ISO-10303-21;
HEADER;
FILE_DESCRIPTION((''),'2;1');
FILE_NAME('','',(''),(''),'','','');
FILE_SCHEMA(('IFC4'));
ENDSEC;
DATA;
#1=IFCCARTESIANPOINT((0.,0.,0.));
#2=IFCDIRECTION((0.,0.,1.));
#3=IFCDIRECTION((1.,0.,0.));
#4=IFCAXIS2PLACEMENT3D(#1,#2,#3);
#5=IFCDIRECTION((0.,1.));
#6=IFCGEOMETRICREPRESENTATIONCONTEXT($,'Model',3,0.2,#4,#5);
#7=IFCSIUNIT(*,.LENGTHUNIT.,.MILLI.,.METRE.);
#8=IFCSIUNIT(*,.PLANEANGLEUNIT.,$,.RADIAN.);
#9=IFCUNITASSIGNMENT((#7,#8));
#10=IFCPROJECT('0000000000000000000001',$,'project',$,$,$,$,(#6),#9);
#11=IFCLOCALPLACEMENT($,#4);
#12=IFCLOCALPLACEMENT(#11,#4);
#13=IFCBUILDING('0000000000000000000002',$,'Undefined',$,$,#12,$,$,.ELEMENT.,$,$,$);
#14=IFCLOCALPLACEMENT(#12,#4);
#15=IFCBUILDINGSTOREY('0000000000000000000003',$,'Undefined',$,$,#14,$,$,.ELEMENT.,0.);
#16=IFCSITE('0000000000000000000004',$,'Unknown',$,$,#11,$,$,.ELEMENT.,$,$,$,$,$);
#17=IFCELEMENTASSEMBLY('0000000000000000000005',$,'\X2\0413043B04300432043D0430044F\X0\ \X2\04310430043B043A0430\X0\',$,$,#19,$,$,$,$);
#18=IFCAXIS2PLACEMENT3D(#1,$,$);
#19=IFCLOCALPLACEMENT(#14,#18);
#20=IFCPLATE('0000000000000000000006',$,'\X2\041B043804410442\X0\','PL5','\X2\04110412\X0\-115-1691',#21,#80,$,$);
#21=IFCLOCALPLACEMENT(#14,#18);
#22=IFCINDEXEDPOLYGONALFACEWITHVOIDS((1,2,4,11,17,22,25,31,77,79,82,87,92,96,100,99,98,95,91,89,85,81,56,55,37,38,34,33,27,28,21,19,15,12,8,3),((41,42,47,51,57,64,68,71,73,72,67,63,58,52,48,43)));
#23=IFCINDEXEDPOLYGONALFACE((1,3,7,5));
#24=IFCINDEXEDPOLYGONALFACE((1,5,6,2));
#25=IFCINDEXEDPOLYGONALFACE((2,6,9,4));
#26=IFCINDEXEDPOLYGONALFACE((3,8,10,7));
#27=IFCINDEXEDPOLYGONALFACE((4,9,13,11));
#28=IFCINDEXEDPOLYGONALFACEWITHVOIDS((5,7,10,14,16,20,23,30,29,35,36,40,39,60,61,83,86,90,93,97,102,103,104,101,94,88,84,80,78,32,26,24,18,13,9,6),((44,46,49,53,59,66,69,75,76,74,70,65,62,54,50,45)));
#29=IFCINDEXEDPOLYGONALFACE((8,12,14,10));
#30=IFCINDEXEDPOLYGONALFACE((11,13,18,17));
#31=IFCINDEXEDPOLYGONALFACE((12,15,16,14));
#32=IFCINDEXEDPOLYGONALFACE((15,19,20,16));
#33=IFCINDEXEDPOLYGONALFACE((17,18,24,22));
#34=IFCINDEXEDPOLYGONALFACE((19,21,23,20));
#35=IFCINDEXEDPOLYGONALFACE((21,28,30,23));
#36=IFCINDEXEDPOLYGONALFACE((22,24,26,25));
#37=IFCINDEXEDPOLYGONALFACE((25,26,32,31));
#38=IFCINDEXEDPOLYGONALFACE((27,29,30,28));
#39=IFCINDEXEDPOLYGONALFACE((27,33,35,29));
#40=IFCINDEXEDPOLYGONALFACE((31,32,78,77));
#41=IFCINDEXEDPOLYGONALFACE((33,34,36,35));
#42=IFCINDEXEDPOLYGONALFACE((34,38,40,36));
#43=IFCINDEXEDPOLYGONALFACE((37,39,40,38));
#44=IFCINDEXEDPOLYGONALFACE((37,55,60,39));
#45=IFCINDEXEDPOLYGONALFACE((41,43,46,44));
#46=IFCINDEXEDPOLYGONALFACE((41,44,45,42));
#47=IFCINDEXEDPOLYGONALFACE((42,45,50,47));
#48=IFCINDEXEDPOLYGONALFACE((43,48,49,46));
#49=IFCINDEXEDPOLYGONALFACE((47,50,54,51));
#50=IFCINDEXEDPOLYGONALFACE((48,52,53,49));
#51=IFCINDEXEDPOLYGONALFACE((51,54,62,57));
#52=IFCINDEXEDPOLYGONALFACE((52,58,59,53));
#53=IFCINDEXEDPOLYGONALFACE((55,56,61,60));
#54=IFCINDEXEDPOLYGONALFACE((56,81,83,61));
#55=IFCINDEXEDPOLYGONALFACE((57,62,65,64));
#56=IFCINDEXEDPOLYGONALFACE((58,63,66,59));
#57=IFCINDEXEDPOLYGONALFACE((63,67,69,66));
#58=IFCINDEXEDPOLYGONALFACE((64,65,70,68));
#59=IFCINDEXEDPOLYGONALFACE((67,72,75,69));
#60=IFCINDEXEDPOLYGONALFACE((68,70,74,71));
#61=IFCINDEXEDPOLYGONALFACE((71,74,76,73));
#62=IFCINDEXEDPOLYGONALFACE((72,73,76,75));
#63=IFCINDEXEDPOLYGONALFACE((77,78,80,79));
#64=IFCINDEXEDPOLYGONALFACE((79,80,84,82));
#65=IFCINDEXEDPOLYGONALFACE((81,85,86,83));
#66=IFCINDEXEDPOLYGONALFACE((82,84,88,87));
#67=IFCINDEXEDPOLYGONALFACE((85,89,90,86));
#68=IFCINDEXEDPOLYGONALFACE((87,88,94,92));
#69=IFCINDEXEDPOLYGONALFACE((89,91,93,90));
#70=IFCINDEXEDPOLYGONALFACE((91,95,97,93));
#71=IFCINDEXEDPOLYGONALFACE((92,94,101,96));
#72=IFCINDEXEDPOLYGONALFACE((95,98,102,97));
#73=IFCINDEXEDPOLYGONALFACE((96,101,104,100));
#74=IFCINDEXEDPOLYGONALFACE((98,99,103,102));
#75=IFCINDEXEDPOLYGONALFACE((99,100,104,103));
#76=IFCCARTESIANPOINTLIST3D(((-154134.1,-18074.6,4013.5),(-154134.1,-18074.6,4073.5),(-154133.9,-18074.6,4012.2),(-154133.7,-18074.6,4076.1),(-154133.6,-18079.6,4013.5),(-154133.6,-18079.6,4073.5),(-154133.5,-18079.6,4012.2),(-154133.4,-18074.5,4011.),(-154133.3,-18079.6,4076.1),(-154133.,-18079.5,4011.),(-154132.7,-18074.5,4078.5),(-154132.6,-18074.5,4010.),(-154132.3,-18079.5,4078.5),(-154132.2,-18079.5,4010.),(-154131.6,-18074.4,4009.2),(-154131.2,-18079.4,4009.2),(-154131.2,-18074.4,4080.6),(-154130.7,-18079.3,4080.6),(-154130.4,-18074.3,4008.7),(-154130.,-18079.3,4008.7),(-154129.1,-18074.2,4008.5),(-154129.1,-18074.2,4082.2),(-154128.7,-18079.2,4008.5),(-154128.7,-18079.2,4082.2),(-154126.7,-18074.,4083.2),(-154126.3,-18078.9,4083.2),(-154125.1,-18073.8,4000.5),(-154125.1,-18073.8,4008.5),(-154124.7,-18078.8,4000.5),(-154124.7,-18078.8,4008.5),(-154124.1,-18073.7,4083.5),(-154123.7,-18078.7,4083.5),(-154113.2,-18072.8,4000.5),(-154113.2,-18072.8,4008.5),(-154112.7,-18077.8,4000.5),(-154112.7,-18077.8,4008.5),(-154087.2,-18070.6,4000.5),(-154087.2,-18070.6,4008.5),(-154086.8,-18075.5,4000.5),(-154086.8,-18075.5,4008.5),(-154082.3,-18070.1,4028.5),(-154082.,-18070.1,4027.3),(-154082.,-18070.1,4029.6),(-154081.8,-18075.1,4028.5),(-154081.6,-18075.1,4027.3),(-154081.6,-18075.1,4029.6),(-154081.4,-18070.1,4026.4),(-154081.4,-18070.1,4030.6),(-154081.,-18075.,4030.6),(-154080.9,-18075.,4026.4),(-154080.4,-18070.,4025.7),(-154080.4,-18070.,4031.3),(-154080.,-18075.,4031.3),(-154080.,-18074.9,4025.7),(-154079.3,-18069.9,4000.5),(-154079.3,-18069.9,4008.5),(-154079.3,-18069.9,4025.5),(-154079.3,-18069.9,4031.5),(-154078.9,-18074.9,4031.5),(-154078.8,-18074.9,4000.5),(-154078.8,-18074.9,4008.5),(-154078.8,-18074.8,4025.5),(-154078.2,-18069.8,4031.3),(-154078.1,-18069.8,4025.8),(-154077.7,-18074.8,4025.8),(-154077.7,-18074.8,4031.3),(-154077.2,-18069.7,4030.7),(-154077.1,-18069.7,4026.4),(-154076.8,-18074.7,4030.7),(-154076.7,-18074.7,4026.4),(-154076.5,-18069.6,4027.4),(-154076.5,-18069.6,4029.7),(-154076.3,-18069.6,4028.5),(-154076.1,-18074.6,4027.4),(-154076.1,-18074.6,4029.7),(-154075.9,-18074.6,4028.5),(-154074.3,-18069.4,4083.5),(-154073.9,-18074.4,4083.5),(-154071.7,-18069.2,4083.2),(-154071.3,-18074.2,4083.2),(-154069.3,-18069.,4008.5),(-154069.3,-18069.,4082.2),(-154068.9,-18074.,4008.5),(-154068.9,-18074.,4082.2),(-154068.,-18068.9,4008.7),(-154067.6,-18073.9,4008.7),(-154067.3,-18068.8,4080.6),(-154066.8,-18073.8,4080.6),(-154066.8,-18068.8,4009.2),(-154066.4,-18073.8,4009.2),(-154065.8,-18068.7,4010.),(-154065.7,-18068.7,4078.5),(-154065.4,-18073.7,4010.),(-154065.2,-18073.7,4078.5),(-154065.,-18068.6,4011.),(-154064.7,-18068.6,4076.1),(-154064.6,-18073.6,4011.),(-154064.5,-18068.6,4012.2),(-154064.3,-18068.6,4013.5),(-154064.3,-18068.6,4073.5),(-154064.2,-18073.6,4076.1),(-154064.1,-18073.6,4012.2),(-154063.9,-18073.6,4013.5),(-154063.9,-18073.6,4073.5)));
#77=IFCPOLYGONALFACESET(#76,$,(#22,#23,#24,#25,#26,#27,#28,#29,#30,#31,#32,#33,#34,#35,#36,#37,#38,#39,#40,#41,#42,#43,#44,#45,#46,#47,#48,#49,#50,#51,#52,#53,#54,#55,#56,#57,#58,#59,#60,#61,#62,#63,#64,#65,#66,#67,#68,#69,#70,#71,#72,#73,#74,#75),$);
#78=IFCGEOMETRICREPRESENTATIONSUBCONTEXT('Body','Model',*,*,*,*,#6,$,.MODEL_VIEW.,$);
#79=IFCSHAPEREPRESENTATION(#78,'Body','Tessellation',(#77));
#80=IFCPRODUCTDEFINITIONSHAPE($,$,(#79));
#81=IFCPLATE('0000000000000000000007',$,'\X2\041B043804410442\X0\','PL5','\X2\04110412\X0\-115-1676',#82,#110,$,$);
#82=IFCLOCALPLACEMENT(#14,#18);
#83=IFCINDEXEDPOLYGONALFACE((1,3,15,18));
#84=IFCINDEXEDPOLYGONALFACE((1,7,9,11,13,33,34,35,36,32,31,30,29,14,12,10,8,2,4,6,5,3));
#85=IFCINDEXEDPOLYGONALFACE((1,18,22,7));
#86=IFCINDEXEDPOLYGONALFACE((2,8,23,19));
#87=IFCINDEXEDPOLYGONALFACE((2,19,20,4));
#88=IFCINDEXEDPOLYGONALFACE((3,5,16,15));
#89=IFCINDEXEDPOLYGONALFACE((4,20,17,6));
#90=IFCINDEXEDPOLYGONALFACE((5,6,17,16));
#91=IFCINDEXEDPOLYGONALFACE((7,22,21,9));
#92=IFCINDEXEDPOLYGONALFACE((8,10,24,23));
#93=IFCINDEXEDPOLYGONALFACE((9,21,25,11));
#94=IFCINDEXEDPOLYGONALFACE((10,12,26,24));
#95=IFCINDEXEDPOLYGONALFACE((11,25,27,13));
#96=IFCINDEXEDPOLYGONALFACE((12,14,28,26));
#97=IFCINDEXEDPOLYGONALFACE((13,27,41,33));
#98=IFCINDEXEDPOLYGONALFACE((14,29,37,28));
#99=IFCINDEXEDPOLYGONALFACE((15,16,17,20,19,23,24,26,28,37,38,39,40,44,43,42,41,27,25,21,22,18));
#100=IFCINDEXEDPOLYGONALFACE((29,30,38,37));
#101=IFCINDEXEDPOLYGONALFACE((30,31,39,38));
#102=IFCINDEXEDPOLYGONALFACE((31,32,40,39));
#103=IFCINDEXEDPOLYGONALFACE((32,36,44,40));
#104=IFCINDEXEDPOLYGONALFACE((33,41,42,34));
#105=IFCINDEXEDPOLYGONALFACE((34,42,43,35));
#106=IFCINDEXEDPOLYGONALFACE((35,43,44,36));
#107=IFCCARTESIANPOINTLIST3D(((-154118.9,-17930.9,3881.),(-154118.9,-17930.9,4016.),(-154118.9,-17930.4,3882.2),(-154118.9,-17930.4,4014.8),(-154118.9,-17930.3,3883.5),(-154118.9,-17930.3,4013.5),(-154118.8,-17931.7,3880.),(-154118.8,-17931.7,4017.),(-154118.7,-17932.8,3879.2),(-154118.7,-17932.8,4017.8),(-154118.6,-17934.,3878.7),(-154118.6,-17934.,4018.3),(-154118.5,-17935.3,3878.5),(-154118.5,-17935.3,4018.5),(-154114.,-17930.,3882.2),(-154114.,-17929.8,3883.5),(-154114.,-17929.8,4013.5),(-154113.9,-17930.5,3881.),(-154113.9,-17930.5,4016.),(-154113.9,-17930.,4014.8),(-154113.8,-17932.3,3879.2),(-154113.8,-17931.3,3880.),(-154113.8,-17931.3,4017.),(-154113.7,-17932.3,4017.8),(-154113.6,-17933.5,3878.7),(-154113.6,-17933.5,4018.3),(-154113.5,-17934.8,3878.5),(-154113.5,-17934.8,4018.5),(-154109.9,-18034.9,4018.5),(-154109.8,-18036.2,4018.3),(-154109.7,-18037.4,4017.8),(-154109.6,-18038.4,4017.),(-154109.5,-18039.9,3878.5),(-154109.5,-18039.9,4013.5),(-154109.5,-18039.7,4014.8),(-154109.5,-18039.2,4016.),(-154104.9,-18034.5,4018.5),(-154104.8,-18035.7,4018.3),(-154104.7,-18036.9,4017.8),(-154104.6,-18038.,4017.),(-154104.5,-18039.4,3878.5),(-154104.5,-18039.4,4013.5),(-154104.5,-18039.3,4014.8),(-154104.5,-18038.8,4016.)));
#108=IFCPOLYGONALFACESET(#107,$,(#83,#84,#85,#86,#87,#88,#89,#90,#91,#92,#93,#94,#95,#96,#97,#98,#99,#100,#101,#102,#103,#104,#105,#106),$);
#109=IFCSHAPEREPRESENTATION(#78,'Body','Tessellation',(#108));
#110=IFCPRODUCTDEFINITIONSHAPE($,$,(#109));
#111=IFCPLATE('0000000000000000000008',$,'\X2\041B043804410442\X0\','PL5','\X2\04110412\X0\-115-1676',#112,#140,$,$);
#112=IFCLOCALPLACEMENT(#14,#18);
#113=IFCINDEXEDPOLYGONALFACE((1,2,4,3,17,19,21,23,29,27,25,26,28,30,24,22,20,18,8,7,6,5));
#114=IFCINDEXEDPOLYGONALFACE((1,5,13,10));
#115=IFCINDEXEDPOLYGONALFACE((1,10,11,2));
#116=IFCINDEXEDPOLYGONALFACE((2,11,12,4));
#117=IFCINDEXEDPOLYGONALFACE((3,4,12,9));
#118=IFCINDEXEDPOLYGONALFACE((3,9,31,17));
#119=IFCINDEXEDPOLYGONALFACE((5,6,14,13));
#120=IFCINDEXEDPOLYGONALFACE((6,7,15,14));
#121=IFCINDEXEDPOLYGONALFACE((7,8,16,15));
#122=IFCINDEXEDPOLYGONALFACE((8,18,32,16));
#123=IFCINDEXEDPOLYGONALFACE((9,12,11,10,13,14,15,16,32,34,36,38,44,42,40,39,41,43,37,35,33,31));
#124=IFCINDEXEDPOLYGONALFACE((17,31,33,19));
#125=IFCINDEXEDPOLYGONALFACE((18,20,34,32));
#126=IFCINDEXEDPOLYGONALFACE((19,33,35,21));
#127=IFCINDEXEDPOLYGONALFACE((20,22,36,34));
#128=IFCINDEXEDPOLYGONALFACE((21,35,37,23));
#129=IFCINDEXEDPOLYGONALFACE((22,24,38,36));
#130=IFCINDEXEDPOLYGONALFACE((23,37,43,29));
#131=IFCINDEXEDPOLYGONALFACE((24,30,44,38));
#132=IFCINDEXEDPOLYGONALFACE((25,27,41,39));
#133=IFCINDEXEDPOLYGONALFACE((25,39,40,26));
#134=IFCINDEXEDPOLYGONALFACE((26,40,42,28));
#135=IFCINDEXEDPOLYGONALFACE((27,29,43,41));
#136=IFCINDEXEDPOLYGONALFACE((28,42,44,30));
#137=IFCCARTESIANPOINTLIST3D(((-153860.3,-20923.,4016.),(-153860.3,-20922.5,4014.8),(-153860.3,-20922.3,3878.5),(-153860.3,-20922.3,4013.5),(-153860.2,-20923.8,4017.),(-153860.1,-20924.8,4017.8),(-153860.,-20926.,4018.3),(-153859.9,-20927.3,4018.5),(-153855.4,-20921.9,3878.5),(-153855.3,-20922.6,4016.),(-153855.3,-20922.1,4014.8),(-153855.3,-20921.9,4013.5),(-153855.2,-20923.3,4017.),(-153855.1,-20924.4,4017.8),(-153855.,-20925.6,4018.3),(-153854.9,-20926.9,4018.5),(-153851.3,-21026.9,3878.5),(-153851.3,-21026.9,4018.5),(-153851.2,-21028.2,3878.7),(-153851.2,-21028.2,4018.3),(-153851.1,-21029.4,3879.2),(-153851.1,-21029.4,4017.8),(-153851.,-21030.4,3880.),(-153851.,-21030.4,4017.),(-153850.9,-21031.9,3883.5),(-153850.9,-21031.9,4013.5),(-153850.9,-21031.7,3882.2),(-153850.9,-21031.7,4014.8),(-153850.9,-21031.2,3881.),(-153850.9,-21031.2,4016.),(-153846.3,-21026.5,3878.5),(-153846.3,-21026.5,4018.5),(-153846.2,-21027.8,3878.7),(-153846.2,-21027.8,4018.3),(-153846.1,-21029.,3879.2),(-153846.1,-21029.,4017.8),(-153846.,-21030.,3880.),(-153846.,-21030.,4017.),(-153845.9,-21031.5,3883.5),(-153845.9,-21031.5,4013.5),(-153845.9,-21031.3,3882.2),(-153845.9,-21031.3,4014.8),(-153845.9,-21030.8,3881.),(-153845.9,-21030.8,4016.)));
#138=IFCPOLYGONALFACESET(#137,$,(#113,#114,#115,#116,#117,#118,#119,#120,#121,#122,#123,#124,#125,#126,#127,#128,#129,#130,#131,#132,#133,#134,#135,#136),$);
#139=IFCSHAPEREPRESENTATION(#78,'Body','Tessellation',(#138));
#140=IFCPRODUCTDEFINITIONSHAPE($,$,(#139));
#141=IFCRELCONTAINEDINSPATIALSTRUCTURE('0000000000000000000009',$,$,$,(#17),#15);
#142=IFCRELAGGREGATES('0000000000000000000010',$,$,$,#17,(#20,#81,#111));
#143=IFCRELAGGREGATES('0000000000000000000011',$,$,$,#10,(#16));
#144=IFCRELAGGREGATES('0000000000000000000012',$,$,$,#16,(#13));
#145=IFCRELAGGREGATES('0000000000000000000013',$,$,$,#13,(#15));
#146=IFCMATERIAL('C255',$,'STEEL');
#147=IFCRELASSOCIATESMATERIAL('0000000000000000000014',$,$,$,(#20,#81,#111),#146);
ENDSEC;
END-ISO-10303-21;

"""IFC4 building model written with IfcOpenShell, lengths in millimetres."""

from ifc_helpers import new_model, si_unit, direction, frame, origin_with_axes, place, context, subcontext, project, spatial, line, arc, indexed_curve, outline, extrude, material, element, aggregate, save


model = new_model("IFC4")

# Units and contexts
model_context = context("Model", 3, precision=0.2, world=origin_with_axes(), true_north=direction((0.0, 1.0)))
body_context = subcontext(model_context, "Body", "Model", "MODEL_VIEW")
ifc_project = project(units=[si_unit("LENGTHUNIT", "METRE", prefix="MILLI"), si_unit("PLANEANGLEUNIT", "RADIAN")], contexts=[model_context])

# Site, building, storey
site_placement = place(None, origin_with_axes())
site = spatial("IfcSite", under=ifc_project, at=site_placement, Name="Unknown", CompositionType="ELEMENT")
building_placement = place(site_placement, origin_with_axes())
building = spatial("IfcBuilding", under=site, at=building_placement, Name="Undefined", CompositionType="ELEMENT")
storey_placement = place(building_placement, origin_with_axes())
storey = spatial("IfcBuildingStorey", under=building, at=storey_placement, Name="Undefined", CompositionType="ELEMENT", Elevation=0.0)

# Shared definitions
ifc_material_1 = material(Name="C255", Category="STEEL")

# Element assembly, plates, voiding feature
assembly_1_placement = place(storey_placement, frame((-154120.8, -17880.2, 3948.5), z_axis=(-0.996285, -0.086114, 0.000024), x_axis=(0.086114, -0.996285, 0.0)))
assembly_1 = element("IfcElementAssembly", 1, at=assembly_1_placement, inside=storey, Name="Главная балка")
plate_1_placement = place(assembly_1_placement, frame((195.0, 135.0, -40.0), z_axis=(1.0, 0.000054, 0.0), x_axis=(0.0, -0.000054, 1.0)))
plate_1 = element("IfcPlate", 2, at=plate_1_placement, material=ifc_material_1, Name="Лист", Description="PL5", ObjectType="БВ-115-1691", context=body_context, shape_type="SolidModel", body=[
    extrude(outline(indexed_curve([(0.0, 10.0), (2.9, 2.9), (10.0, 0.0), (60.0, 0.0), (67.1, 2.9), (70.0, 10.0), (70.0, 70.0), (68.5, 73.5), (65.0, 75.0), (61.0, 75.0), (61.0, 83.0), (49.0, 83.0), (49.0, 75.0), (23.0, 75.0), (23.0, 83.0), (15.0, 83.0), (15.0, 75.0), (5.0, 75.0), (1.5, 73.5), (0.0, 70.0)], segments=[arc(1, 2, 3), line(3, 4), arc(4, 5, 6), line(6, 7), arc(7, 8, 9), line(9, 10, 11, 12, 13, 14, 15, 16, 17, 18), arc(18, 19, 20), line(20, 1)])), frame((0.0, 0.0, 2.5), z_axis=(0.0, 0.0, 1.0), x_axis=(1.0, 0.0, 0.0)), (0.0, 0.0, -1.0), 5.0),
])
voiding_feature_1_placement = place(plate_1_placement, frame((15.0, 55.0, 10.0), z_axis=(0.007997, -0.999968, -0.000026), x_axis=(0.0, 0.000026, -1.0)))
element("IfcVoidingFeature", 3, at=voiding_feature_1_placement, cuts=plate_1, Name="Балка", ObjectType="(?)", PredefinedType="HOLE", context=body_context, shape_type="SolidModel", body=[
    extrude(outline(indexed_curve([(3.0, 0.0), (2.8, 1.1), (2.1, 2.1), (1.1, 2.8), (0.0, 3.0), (-1.1, 2.8), (-2.1, 2.1), (-2.8, 1.1), (-3.0, 0.0), (-2.8, -1.1), (-2.1, -2.1), (-1.1, -2.8), (0.0, -3.0), (1.1, -2.8), (2.1, -2.1), (2.8, -1.1)], segments=[line(1, 2, 3, 4, 5, 6, 7, 8, 9, 10, 11, 12, 13, 14, 15, 16, 1)])), frame((0.0, 0.0, 0.0), z_axis=(-1.0, 0.0, 0.0), x_axis=(0.0, 0.0, 1.0)), (0.0, 0.0, -1.0), 20.0),
])
plate_2_placement = place(assembly_1_placement, frame((50.0, 70.0, 0.0), z_axis=(0.0, 0.0, 1.0), x_axis=(0.0, -1.0, 0.0)))
plate_2 = element("IfcPlate", 4, at=plate_2_placement, material=ifc_material_1, Name="Лист", Description="PL5", ObjectType="БВ-115-1676", context=body_context, shape_type="SolidModel", body=[
    extrude(outline(indexed_curve([(0.0, 5.0), (1.5, 1.5), (5.0, 0.0), (135.0, 0.0), (138.5, 1.5), (140.0, 5.0), (140.0, 110.0), (5.0, 110.0), (1.5, 108.5), (0.0, 105.0)], segments=[arc(1, 2, 3), line(3, 4), arc(4, 5, 6), line(6, 7, 8), arc(8, 9, 10), line(10, 1)])), frame((0.0, 0.0, 2.5), z_axis=(0.0, 0.0, 1.0), x_axis=(1.0, 0.0, 0.0)), (0.0, 0.0, -1.0), 5.0),
])
plate_3_placement = place(assembly_1_placement, frame((3163.2, 70.0, 0.0), z_axis=(0.0, 0.0, -1.0), x_axis=(0.0, -1.0, 0.0)))
plate_3 = element("IfcPlate", 5, at=plate_3_placement, material=ifc_material_1, Name="Лист", Description="PL5", ObjectType="БВ-115-1676", context=body_context, shape_type="SolidModel", body=[
    extrude(outline(indexed_curve([(0.0, 5.0), (1.5, 1.5), (5.0, 0.0), (135.0, 0.0), (138.5, 1.5), (140.0, 5.0), (140.0, 110.0), (5.0, 110.0), (1.5, 108.5), (0.0, 105.0)], segments=[arc(1, 2, 3), line(3, 4), arc(4, 5, 6), line(6, 7, 8), arc(8, 9, 10), line(10, 1)])), frame((0.0, 0.0, 2.5), z_axis=(0.0, 0.0, 1.0), x_axis=(1.0, 0.0, 0.0)), (0.0, 0.0, -1.0), 5.0),
])

aggregate(assembly_1, [plate_1, plate_2, plate_3])

save(model, "model.ifc")
